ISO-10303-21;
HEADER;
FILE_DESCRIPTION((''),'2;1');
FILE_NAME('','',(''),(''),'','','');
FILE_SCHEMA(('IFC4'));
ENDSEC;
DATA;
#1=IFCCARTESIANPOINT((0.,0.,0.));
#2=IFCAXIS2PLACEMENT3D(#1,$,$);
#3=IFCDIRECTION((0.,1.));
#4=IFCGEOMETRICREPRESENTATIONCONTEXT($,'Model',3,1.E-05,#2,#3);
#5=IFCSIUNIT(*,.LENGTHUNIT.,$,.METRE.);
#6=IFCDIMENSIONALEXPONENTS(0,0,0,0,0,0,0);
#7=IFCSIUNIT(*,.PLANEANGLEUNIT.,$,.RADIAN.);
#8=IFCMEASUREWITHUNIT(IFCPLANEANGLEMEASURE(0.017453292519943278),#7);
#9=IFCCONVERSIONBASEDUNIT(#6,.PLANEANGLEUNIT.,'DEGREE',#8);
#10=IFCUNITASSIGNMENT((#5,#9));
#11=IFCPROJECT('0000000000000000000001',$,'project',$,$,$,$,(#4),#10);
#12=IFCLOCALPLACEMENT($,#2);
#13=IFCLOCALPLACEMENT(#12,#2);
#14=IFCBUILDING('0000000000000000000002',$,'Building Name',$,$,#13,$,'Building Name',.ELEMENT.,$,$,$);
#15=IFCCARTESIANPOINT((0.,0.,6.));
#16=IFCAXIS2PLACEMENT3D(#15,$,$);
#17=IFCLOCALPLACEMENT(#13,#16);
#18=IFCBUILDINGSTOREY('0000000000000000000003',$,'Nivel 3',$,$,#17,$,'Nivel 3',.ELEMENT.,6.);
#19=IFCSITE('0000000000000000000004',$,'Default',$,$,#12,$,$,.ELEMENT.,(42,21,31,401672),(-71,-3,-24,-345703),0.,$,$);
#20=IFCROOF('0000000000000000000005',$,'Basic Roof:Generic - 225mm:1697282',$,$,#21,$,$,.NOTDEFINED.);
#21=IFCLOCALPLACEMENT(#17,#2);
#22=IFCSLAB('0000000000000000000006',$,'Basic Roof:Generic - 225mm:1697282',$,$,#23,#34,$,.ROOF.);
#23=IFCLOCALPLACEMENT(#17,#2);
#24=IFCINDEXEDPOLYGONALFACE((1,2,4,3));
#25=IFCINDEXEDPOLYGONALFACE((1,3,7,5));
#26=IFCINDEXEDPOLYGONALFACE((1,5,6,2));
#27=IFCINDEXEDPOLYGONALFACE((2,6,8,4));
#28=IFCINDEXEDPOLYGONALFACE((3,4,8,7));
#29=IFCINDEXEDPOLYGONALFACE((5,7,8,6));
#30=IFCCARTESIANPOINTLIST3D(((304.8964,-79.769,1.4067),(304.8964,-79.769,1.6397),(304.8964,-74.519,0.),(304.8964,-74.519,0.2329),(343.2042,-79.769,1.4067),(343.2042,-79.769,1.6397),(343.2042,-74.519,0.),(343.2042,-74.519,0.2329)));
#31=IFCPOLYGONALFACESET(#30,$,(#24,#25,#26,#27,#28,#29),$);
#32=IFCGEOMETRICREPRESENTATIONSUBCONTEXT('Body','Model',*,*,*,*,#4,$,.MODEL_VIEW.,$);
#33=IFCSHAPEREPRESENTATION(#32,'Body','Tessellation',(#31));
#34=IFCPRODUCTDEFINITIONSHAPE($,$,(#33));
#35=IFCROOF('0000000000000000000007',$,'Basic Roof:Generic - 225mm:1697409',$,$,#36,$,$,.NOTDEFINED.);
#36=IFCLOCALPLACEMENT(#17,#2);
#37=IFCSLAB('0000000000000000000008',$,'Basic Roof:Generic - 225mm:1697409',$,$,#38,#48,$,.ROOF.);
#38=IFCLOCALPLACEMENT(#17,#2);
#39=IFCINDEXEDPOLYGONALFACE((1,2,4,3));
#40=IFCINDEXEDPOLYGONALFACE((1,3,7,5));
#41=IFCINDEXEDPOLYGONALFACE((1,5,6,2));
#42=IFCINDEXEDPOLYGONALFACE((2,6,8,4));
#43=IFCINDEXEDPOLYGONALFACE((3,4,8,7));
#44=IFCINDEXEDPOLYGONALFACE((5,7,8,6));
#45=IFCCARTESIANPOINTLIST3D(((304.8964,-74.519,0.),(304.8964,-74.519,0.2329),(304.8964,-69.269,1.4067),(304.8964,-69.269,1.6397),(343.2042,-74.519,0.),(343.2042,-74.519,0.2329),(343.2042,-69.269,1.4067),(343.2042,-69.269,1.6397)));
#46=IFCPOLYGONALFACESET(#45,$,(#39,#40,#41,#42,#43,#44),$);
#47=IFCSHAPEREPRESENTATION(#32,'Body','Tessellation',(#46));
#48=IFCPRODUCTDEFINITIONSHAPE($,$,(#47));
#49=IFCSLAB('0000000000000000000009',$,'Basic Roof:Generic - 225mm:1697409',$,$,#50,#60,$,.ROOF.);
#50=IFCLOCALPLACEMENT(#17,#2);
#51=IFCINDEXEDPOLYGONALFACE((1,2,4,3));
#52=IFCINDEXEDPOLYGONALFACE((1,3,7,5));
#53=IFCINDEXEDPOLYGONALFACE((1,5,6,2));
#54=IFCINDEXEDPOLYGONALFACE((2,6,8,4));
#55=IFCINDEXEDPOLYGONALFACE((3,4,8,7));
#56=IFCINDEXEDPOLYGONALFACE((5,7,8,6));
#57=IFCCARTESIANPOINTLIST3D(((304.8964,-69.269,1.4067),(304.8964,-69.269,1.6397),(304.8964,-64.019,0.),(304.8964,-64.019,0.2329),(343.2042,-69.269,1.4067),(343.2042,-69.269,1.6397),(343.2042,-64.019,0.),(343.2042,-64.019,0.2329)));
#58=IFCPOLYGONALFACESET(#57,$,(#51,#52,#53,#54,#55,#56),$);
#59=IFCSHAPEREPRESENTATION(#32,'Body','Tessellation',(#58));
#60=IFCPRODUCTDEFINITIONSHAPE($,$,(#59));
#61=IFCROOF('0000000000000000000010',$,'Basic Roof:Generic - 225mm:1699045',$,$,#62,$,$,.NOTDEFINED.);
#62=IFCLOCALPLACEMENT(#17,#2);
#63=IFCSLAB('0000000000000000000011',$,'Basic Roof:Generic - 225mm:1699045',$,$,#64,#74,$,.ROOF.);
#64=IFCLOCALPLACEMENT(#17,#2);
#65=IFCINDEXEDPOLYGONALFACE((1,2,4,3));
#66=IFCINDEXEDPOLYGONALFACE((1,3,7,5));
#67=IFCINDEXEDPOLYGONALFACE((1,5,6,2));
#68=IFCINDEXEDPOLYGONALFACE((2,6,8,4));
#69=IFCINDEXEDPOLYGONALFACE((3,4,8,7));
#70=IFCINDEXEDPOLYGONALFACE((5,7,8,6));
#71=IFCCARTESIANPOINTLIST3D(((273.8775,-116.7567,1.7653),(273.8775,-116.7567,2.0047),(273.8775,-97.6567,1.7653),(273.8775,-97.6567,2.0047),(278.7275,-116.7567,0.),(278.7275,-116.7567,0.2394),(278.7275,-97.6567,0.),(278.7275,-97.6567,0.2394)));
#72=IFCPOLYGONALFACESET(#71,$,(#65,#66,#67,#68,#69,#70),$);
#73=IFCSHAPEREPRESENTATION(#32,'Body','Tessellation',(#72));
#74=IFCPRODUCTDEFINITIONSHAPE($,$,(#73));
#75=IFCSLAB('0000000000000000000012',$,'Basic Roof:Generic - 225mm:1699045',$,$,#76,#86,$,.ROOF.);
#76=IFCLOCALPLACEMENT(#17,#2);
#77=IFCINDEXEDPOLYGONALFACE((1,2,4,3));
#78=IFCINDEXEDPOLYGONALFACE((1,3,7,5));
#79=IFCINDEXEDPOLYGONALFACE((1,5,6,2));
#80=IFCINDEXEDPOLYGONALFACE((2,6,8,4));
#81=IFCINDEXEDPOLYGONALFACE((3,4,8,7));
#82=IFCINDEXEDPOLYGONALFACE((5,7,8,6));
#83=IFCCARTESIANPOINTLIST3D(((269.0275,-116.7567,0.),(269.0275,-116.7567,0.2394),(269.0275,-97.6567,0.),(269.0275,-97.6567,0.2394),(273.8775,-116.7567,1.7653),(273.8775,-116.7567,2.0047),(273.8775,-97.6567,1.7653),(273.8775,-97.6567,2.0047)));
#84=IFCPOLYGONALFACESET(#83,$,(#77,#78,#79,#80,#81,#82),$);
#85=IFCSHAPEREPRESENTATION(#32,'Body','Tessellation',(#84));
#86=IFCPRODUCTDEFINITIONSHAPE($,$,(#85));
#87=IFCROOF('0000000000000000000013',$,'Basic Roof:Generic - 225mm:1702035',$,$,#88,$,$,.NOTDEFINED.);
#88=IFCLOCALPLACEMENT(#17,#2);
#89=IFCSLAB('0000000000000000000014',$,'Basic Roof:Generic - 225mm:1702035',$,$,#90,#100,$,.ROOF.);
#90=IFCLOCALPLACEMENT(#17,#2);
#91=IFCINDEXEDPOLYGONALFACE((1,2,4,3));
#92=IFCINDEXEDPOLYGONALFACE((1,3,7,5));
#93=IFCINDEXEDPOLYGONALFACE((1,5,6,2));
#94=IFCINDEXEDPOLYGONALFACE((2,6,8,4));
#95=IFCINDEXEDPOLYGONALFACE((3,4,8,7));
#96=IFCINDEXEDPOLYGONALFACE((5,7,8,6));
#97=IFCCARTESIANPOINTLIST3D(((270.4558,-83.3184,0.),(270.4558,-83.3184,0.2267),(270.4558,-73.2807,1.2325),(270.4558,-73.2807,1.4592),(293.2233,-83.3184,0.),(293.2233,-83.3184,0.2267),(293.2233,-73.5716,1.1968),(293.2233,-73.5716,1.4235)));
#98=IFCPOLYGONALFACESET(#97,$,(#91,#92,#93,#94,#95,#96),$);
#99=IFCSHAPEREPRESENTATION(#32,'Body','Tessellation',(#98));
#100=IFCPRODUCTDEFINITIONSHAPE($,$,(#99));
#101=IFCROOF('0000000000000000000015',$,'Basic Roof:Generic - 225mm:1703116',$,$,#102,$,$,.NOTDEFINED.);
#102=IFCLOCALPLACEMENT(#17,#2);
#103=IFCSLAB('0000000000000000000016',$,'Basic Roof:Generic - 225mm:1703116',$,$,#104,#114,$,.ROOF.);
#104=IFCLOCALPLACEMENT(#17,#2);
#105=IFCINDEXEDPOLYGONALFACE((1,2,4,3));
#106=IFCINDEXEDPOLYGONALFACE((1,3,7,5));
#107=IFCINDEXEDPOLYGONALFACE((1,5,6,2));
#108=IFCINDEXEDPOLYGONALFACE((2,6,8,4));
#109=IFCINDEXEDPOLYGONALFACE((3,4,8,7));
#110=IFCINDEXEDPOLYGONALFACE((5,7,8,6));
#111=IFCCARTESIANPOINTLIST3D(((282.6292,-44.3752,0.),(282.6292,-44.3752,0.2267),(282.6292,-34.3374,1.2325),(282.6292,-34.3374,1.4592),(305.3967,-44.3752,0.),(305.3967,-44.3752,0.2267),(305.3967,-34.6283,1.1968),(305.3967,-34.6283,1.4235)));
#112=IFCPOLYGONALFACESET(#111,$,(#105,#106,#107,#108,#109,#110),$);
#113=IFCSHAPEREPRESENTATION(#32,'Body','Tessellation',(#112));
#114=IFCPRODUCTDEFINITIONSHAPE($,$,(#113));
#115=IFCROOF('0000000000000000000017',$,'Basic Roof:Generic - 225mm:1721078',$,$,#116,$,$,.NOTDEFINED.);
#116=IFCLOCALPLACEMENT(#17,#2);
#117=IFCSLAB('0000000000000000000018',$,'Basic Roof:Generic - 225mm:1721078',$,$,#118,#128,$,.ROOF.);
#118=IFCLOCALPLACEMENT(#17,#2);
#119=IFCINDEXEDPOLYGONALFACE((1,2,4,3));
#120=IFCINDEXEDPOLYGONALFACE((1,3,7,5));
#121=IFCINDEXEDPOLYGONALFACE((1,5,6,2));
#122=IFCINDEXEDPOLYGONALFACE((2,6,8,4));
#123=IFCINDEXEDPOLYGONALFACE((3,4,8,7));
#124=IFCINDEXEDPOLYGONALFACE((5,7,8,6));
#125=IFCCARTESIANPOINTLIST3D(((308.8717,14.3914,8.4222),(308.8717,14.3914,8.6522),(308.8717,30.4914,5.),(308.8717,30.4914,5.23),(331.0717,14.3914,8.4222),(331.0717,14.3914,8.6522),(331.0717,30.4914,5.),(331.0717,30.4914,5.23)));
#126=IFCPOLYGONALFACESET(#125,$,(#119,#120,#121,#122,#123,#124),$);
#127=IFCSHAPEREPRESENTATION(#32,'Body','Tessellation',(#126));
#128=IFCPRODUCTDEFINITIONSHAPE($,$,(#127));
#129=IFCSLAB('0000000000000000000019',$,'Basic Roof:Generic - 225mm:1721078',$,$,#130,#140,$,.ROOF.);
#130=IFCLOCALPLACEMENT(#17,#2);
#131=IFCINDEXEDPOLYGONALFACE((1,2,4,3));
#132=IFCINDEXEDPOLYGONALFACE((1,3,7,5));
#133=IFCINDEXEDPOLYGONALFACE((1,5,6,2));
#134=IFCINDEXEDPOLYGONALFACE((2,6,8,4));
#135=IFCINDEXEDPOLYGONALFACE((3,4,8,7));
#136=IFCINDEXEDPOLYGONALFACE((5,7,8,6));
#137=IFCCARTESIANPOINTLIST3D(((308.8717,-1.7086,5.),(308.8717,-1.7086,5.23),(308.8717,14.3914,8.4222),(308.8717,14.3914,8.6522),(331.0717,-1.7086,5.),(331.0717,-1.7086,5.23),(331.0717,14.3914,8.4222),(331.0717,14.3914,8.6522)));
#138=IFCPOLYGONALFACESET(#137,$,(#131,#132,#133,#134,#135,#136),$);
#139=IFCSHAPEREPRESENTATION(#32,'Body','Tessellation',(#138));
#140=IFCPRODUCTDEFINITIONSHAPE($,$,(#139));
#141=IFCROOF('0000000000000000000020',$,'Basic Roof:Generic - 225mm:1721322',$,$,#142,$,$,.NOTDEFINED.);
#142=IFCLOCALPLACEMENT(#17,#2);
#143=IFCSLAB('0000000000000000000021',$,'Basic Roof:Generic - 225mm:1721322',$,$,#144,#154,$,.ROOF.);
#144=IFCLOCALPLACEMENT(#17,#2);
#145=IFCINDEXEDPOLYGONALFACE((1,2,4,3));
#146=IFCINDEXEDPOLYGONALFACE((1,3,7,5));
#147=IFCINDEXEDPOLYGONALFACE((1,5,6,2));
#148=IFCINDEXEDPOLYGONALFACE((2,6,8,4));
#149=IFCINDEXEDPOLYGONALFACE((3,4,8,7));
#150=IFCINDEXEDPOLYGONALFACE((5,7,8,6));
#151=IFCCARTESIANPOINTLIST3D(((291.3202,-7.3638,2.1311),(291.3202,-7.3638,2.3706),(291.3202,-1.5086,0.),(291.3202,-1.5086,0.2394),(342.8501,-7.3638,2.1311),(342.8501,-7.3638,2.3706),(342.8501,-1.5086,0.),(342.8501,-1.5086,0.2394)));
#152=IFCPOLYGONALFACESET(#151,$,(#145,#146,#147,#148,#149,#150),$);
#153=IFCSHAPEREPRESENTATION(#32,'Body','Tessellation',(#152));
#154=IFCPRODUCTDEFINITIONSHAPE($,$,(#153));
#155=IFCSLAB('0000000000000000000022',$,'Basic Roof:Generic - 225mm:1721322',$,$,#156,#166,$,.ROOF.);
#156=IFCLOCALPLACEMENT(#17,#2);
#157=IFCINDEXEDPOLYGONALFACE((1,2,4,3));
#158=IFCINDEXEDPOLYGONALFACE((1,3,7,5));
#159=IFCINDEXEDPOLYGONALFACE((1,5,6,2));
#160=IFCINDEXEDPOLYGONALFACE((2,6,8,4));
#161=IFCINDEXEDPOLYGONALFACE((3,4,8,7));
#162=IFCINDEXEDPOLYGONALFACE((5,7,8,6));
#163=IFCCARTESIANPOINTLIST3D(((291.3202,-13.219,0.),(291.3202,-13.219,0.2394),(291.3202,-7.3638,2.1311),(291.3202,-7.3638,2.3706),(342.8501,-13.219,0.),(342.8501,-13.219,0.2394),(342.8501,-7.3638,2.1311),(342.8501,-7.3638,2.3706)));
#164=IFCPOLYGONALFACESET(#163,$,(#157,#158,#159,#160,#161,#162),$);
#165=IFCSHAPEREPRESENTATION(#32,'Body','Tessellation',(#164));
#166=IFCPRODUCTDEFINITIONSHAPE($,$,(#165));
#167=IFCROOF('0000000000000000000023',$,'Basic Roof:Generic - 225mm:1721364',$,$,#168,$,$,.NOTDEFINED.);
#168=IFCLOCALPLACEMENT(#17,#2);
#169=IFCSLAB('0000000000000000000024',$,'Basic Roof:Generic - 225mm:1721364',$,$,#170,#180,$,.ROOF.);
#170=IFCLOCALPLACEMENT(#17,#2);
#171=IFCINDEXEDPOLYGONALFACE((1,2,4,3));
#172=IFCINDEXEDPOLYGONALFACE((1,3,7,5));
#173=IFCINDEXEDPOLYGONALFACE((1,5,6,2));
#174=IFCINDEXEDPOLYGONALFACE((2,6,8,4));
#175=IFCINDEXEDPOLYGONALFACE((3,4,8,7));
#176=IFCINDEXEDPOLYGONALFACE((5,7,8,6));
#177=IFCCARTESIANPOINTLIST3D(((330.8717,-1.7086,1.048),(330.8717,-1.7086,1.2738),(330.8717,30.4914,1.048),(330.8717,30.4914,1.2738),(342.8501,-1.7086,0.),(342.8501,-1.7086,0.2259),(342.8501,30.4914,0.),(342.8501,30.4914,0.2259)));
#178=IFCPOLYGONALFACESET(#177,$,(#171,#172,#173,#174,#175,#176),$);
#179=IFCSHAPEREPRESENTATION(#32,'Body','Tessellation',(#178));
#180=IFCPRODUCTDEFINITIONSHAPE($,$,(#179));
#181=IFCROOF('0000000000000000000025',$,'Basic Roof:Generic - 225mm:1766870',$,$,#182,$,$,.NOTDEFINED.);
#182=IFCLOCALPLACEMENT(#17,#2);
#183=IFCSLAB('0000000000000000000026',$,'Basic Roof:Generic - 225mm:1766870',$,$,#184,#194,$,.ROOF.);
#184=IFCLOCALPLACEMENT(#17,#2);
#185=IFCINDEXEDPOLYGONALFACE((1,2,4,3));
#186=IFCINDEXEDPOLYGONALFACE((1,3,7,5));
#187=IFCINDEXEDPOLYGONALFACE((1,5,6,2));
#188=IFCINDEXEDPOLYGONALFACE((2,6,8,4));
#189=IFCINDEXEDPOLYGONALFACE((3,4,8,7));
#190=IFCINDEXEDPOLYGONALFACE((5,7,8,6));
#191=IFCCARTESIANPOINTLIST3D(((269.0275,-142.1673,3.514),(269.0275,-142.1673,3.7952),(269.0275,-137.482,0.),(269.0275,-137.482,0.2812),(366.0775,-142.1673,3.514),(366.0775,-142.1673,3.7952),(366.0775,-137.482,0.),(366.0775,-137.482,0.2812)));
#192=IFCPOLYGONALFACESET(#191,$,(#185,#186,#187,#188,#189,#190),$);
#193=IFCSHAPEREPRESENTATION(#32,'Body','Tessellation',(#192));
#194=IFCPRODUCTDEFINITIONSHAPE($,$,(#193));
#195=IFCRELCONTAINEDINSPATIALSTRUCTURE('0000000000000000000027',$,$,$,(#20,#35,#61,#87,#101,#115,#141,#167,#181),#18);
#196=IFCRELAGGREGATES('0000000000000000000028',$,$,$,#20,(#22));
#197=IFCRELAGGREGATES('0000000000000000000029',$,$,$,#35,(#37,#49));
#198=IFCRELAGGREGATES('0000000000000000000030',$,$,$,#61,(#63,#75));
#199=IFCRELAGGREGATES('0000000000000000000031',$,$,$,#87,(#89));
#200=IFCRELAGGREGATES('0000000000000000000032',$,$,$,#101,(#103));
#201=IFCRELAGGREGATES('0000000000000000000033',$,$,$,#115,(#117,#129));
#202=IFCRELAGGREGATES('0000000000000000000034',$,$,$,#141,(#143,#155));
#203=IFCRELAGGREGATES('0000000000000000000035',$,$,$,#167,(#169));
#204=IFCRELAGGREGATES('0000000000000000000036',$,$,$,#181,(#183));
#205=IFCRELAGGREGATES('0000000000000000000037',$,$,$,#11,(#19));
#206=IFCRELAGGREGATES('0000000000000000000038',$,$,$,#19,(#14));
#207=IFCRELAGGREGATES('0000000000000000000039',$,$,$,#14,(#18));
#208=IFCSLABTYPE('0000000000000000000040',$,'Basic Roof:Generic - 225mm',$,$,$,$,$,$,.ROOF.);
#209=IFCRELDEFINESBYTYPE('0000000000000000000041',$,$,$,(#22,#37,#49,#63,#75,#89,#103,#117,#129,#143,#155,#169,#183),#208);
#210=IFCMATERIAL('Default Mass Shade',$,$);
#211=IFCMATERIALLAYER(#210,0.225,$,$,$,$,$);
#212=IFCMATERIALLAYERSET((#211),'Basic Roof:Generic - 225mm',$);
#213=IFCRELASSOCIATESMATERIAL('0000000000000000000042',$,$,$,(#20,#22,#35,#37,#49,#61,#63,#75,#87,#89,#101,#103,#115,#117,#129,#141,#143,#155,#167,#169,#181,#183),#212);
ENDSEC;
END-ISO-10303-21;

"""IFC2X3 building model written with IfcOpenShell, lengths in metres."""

from ifc_helpers import new_model, entity, si_unit, converted_unit, direction, frame, frame_2d, origin, place, context, subcontext, project, spatial, polyline, rectangle, outline, extrude, material, layer, layer_set, type_object, element, aggregate, save


model = new_model("IFC2X3")

# Units and contexts
model_context = context("Model", 3, precision=1e-05, world=origin(), true_north=direction((0.0, 1.0)))
body_context = subcontext(model_context, "Body", "Model", "MODEL_VIEW")
ifc_project = project(units=[si_unit("LENGTHUNIT", "METRE"), converted_unit("PLANEANGLEUNIT", "DEGREE", entity("IfcPlaneAngleMeasure", 0.017453292519943278), si_unit("PLANEANGLEUNIT", "RADIAN"), dimensions=[0, 0, 0, 0, 0, 0, 0])], contexts=[model_context])

# Site, building, storey
site_placement = place(None, origin())
site = spatial("IfcSite", under=ifc_project, at=site_placement, Name="Default", CompositionType="ELEMENT", RefLatitude=(42, 21, 31, 401672), RefLongitude=(-71, -3, -24, -345703), RefElevation=0.0)
building_placement = place(site_placement, origin())
building = spatial("IfcBuilding", under=site, at=building_placement, Name="Building Name", LongName="Building Name", CompositionType="ELEMENT")
storey_placement = place(building_placement, frame((0.0, 0.0, 6.0)))
storey = spatial("IfcBuildingStorey", under=building, at=storey_placement, Name="Nivel 3", LongName="Nivel 3", CompositionType="ELEMENT", Elevation=6.0)

# Roofs, slabs
ifc_material = material(Name="Default Mass Shade")
ifc_layer = layer(ifc_material, 0.225)
ifc_layer_set = layer_set([ifc_layer], Name="Basic Roof:Generic - 225mm")
slab_type = type_object("IfcSlabType", Name="Basic Roof:Generic - 225mm", PredefinedType="ROOF")
roof_1_placement = place(storey_placement, frame((304.8964, -85.019, 0.0)))
roof_1 = element("IfcRoof", 1, at=roof_1_placement, inside=storey, material=ifc_layer_set, Name="Basic Roof:Generic - 225mm:1697282", ShapeType="NOTDEFINED")
slab_1_placement = place(roof_1_placement, origin())
slab_1 = element("IfcSlab", 2, at=slab_1_placement, type_object=slab_type, material=ifc_layer_set, Name="Basic Roof:Generic - 225mm:1697282", PredefinedType="ROOF", context=body_context, shape_type="SweptSolid", body=[
    extrude(rectangle(XDim=38.3079, YDim=5.4352, at=frame_2d((0.0, 0.0), x_axis=(1.0, 0.0))), frame((19.1539, 7.875, 0.7034), z_axis=(0.0, 0.258819, 0.965926), x_axis=(1.0, 0.0, 0.0)), (0.0, -0.258819, 0.965926), 0.2329),
])
aggregate(roof_1, [slab_1])
roof_2_placement = place(storey_placement, frame((304.8964, -74.519, 0.0)))
roof_2 = element("IfcRoof", 3, at=roof_2_placement, inside=storey, material=ifc_layer_set, Name="Basic Roof:Generic - 225mm:1697409", ShapeType="NOTDEFINED")
slab_2_placement = place(roof_2_placement, origin())
slab_2 = element("IfcSlab", 4, at=slab_2_placement, type_object=slab_type, material=ifc_layer_set, Name="Basic Roof:Generic - 225mm:1697409", PredefinedType="ROOF", context=body_context, shape_type="SweptSolid", body=[
    extrude(rectangle(XDim=5.4352, YDim=38.3079, at=frame_2d((0.0, 0.0), x_axis=(0.0, 1.0))), frame((19.1539, 2.625, 0.7034), z_axis=(0.0, -0.258819, 0.965926), x_axis=(1.0, 0.0, 0.0)), (0.0, 0.258819, 0.965926), 0.2329),
])
slab_3_placement = place(roof_2_placement, origin())
slab_3 = element("IfcSlab", 5, at=slab_3_placement, type_object=slab_type, material=ifc_layer_set, Name="Basic Roof:Generic - 225mm:1697409", PredefinedType="ROOF", context=body_context, shape_type="SweptSolid", body=[
    extrude(rectangle(XDim=38.3079, YDim=5.4352, at=frame_2d((0.0, 0.0), x_axis=(1.0, 0.0))), frame((19.1539, 7.875, 0.7034), z_axis=(0.0, 0.258819, 0.965926), x_axis=(1.0, 0.0, 0.0)), (0.0, -0.258819, 0.965926), 0.2329),
])
aggregate(roof_2, [slab_2, slab_3])
roof_3_placement = place(storey_placement, frame((269.0275, -116.7567, 0.0)))
roof_3 = element("IfcRoof", 6, at=roof_3_placement, inside=storey, material=ifc_layer_set, Name="Basic Roof:Generic - 225mm:1699045", ShapeType="NOTDEFINED")
slab_4_placement = place(roof_3_placement, origin())
slab_4 = element("IfcSlab", 7, at=slab_4_placement, type_object=slab_type, material=ifc_layer_set, Name="Basic Roof:Generic - 225mm:1699045", PredefinedType="ROOF", context=body_context, shape_type="SweptSolid", body=[
    extrude(rectangle(XDim=5.1613, YDim=19.1, at=frame_2d((0.0, 0.0), x_axis=(1.0, 0.0))), frame((7.275, 9.55, 0.8826), z_axis=(0.34202, 0.0, 0.939693), x_axis=(0.939693, 0.0, -0.34202)), (-0.34202, 0.0, 0.939693), 0.2394),
])
slab_5_placement = place(roof_3_placement, origin())
slab_5 = element("IfcSlab", 8, at=slab_5_placement, type_object=slab_type, material=ifc_layer_set, Name="Basic Roof:Generic - 225mm:1699045", PredefinedType="ROOF", context=body_context, shape_type="SweptSolid", body=[
    extrude(rectangle(XDim=19.1, YDim=5.1613, at=frame_2d((0.0, 0.0), x_axis=(0.0, 1.0))), frame((2.425, 9.55, 0.8826), z_axis=(-0.34202, 0.0, 0.939693), x_axis=(0.939693, 0.0, 0.34202)), (0.34202, 0.0, 0.939693), 0.2394),
])
aggregate(roof_3, [slab_4, slab_5])
roof_4_placement = place(storey_placement, frame((270.4558, -83.3184, 0.0)))
roof_4 = element("IfcRoof", 9, at=roof_4_placement, inside=storey, material=ifc_layer_set, Name="Basic Roof:Generic - 225mm:1702035", ShapeType="NOTDEFINED")
slab_6_placement = place(roof_4_placement, origin())
slab_6 = element("IfcSlab", 10, at=slab_6_placement, type_object=slab_type, material=ifc_layer_set, Name="Basic Roof:Generic - 225mm:1702035", PredefinedType="ROOF", context=body_context, shape_type="SweptSolid", body=[
    extrude(outline(polyline([(11.3837, -5.0566), (11.3837, 4.7635), (-11.3837, 5.0566), (-11.3837, -5.0566), (11.3837, -5.0566)])), frame((11.3837, 5.0189, 0.6162), z_axis=(0.0, -0.121869, 0.992546), x_axis=(1.0, 0.0, 0.0)), (0.0, 0.121869, 0.992546), 0.2267),
])
aggregate(roof_4, [slab_6])
roof_5_placement = place(storey_placement, frame((282.6292, -44.3752, 0.0)))
roof_5 = element("IfcRoof", 11, at=roof_5_placement, inside=storey, material=ifc_layer_set, Name="Basic Roof:Generic - 225mm:1703116", ShapeType="NOTDEFINED")
slab_7_placement = place(roof_5_placement, origin())
slab_7 = element("IfcSlab", 12, at=slab_7_placement, type_object=slab_type, material=ifc_layer_set, Name="Basic Roof:Generic - 225mm:1703116", PredefinedType="ROOF", context=body_context, shape_type="SweptSolid", body=[
    extrude(outline(polyline([(11.3837, -5.0566), (11.3837, 4.7635), (-11.3837, 5.0566), (-11.3837, -5.0566), (11.3837, -5.0566)])), frame((11.3837, 5.0189, 0.6162), z_axis=(0.0, -0.121869, 0.992546), x_axis=(1.0, 0.0, 0.0)), (0.0, 0.121869, 0.992546), 0.2267),
])
aggregate(roof_5, [slab_7])

# Roofs, slabs
roof_6_placement = place(storey_placement, frame((308.8717, -1.7086, 5.0)))
roof_6 = element("IfcRoof", 13, at=roof_6_placement, inside=storey, material=ifc_layer_set, Name="Basic Roof:Generic - 225mm:1721078", ShapeType="NOTDEFINED")
slab_8_placement = place(roof_6_placement, origin())
slab_8 = element("IfcSlab", 14, at=slab_8_placement, type_object=slab_type, material=ifc_layer_set, Name="Basic Roof:Generic - 225mm:1721078", PredefinedType="ROOF", context=body_context, shape_type="SweptSolid", body=[
    extrude(rectangle(XDim=22.2, YDim=16.4597, at=frame_2d((0.0, 0.0), x_axis=(1.0, 0.0))), frame((11.1, 24.15, 1.7111), z_axis=(0.0, 0.207912, 0.978148), x_axis=(1.0, 0.0, 0.0)), (0.0, -0.207912, 0.978148), 0.23),
])
slab_9_placement = place(roof_6_placement, origin())
slab_9 = element("IfcSlab", 15, at=slab_9_placement, type_object=slab_type, material=ifc_layer_set, Name="Basic Roof:Generic - 225mm:1721078", PredefinedType="ROOF", context=body_context, shape_type="SweptSolid", body=[
    extrude(rectangle(XDim=16.4597, YDim=22.2, at=frame_2d((0.0, 0.0), x_axis=(0.0, 1.0))), frame((11.1, 8.05, 1.7111), z_axis=(0.0, -0.207912, 0.978148), x_axis=(1.0, 0.0, 0.0)), (0.0, 0.207912, 0.978148), 0.23),
])
aggregate(roof_6, [slab_8, slab_9])
roof_7_placement = place(storey_placement, frame((291.3202, -13.219, 0.0)))
roof_7 = element("IfcRoof", 16, at=roof_7_placement, inside=storey, material=ifc_layer_set, Name="Basic Roof:Generic - 225mm:1721322", ShapeType="NOTDEFINED")
slab_10_placement = place(roof_7_placement, origin())
slab_10 = element("IfcSlab", 17, at=slab_10_placement, type_object=slab_type, material=ifc_layer_set, Name="Basic Roof:Generic - 225mm:1721322", PredefinedType="ROOF", context=body_context, shape_type="SweptSolid", body=[
    extrude(rectangle(XDim=51.5299, YDim=6.231, at=frame_2d((0.0, 0.0), x_axis=(1.0, 0.0))), frame((25.765, 8.7828, 1.0656), z_axis=(0.0, 0.34202, 0.939693), x_axis=(1.0, 0.0, 0.0)), (0.0, -0.34202, 0.939693), 0.2394),
])
slab_11_placement = place(roof_7_placement, origin())
slab_11 = element("IfcSlab", 18, at=slab_11_placement, type_object=slab_type, material=ifc_layer_set, Name="Basic Roof:Generic - 225mm:1721322", PredefinedType="ROOF", context=body_context, shape_type="SweptSolid", body=[
    extrude(rectangle(XDim=6.231, YDim=51.5299, at=frame_2d((0.0, 0.0), x_axis=(0.0, 1.0))), frame((25.765, 2.9276, 1.0656), z_axis=(0.0, -0.34202, 0.939693), x_axis=(1.0, 0.0, 0.0)), (0.0, 0.34202, 0.939693), 0.2394),
])
aggregate(roof_7, [slab_10, slab_11])

# Roof, slab
roof_8_placement = place(storey_placement, frame((330.8717, -1.7086, 0.0)))
roof_8 = element("IfcRoof", 19, at=roof_8_placement, inside=storey, material=ifc_layer_set, Name="Basic Roof:Generic - 225mm:1721364", ShapeType="NOTDEFINED")
slab_12_placement = place(roof_8_placement, origin())
slab_12 = element("IfcSlab", 20, at=slab_12_placement, type_object=slab_type, material=ifc_layer_set, Name="Basic Roof:Generic - 225mm:1721364", PredefinedType="ROOF", context=body_context, shape_type="SweptSolid", body=[
    extrude(rectangle(XDim=12.0242, YDim=32.2, at=frame_2d((0.0, 0.0), x_axis=(1.0, 0.0))), frame((5.9892, 16.1, 0.524), z_axis=(0.087156, 0.0, 0.996195), x_axis=(0.996195, 0.0, -0.087156)), (-0.087156, 0.0, 0.996195), 0.2259),
])
aggregate(roof_8, [slab_12])

# Roof, slab
roof_9_placement = place(storey_placement, frame((269.0275, -146.8526, 0.0)))
roof_9 = element("IfcRoof", 21, at=roof_9_placement, inside=storey, material=ifc_layer_set, Name="Basic Roof:Generic - 225mm:1766870", ShapeType="NOTDEFINED")
slab_13_placement = place(roof_9_placement, origin())
slab_13 = element("IfcSlab", 22, at=slab_13_placement, type_object=slab_type, material=ifc_layer_set, Name="Basic Roof:Generic - 225mm:1766870", PredefinedType="ROOF", context=body_context, shape_type="SweptSolid", body=[
    extrude(rectangle(XDim=5.8566, YDim=97.05, at=frame_2d((0.0, 0.0), x_axis=(0.0, -1.0))), frame((48.525, 7.0279, 1.757), z_axis=(0.0, 0.6, 0.8), x_axis=(1.0, 0.0, 0.0)), (0.0, -0.6, 0.8), 0.2812),
])
aggregate(roof_9, [slab_13])

save(model, "model.ifc")
